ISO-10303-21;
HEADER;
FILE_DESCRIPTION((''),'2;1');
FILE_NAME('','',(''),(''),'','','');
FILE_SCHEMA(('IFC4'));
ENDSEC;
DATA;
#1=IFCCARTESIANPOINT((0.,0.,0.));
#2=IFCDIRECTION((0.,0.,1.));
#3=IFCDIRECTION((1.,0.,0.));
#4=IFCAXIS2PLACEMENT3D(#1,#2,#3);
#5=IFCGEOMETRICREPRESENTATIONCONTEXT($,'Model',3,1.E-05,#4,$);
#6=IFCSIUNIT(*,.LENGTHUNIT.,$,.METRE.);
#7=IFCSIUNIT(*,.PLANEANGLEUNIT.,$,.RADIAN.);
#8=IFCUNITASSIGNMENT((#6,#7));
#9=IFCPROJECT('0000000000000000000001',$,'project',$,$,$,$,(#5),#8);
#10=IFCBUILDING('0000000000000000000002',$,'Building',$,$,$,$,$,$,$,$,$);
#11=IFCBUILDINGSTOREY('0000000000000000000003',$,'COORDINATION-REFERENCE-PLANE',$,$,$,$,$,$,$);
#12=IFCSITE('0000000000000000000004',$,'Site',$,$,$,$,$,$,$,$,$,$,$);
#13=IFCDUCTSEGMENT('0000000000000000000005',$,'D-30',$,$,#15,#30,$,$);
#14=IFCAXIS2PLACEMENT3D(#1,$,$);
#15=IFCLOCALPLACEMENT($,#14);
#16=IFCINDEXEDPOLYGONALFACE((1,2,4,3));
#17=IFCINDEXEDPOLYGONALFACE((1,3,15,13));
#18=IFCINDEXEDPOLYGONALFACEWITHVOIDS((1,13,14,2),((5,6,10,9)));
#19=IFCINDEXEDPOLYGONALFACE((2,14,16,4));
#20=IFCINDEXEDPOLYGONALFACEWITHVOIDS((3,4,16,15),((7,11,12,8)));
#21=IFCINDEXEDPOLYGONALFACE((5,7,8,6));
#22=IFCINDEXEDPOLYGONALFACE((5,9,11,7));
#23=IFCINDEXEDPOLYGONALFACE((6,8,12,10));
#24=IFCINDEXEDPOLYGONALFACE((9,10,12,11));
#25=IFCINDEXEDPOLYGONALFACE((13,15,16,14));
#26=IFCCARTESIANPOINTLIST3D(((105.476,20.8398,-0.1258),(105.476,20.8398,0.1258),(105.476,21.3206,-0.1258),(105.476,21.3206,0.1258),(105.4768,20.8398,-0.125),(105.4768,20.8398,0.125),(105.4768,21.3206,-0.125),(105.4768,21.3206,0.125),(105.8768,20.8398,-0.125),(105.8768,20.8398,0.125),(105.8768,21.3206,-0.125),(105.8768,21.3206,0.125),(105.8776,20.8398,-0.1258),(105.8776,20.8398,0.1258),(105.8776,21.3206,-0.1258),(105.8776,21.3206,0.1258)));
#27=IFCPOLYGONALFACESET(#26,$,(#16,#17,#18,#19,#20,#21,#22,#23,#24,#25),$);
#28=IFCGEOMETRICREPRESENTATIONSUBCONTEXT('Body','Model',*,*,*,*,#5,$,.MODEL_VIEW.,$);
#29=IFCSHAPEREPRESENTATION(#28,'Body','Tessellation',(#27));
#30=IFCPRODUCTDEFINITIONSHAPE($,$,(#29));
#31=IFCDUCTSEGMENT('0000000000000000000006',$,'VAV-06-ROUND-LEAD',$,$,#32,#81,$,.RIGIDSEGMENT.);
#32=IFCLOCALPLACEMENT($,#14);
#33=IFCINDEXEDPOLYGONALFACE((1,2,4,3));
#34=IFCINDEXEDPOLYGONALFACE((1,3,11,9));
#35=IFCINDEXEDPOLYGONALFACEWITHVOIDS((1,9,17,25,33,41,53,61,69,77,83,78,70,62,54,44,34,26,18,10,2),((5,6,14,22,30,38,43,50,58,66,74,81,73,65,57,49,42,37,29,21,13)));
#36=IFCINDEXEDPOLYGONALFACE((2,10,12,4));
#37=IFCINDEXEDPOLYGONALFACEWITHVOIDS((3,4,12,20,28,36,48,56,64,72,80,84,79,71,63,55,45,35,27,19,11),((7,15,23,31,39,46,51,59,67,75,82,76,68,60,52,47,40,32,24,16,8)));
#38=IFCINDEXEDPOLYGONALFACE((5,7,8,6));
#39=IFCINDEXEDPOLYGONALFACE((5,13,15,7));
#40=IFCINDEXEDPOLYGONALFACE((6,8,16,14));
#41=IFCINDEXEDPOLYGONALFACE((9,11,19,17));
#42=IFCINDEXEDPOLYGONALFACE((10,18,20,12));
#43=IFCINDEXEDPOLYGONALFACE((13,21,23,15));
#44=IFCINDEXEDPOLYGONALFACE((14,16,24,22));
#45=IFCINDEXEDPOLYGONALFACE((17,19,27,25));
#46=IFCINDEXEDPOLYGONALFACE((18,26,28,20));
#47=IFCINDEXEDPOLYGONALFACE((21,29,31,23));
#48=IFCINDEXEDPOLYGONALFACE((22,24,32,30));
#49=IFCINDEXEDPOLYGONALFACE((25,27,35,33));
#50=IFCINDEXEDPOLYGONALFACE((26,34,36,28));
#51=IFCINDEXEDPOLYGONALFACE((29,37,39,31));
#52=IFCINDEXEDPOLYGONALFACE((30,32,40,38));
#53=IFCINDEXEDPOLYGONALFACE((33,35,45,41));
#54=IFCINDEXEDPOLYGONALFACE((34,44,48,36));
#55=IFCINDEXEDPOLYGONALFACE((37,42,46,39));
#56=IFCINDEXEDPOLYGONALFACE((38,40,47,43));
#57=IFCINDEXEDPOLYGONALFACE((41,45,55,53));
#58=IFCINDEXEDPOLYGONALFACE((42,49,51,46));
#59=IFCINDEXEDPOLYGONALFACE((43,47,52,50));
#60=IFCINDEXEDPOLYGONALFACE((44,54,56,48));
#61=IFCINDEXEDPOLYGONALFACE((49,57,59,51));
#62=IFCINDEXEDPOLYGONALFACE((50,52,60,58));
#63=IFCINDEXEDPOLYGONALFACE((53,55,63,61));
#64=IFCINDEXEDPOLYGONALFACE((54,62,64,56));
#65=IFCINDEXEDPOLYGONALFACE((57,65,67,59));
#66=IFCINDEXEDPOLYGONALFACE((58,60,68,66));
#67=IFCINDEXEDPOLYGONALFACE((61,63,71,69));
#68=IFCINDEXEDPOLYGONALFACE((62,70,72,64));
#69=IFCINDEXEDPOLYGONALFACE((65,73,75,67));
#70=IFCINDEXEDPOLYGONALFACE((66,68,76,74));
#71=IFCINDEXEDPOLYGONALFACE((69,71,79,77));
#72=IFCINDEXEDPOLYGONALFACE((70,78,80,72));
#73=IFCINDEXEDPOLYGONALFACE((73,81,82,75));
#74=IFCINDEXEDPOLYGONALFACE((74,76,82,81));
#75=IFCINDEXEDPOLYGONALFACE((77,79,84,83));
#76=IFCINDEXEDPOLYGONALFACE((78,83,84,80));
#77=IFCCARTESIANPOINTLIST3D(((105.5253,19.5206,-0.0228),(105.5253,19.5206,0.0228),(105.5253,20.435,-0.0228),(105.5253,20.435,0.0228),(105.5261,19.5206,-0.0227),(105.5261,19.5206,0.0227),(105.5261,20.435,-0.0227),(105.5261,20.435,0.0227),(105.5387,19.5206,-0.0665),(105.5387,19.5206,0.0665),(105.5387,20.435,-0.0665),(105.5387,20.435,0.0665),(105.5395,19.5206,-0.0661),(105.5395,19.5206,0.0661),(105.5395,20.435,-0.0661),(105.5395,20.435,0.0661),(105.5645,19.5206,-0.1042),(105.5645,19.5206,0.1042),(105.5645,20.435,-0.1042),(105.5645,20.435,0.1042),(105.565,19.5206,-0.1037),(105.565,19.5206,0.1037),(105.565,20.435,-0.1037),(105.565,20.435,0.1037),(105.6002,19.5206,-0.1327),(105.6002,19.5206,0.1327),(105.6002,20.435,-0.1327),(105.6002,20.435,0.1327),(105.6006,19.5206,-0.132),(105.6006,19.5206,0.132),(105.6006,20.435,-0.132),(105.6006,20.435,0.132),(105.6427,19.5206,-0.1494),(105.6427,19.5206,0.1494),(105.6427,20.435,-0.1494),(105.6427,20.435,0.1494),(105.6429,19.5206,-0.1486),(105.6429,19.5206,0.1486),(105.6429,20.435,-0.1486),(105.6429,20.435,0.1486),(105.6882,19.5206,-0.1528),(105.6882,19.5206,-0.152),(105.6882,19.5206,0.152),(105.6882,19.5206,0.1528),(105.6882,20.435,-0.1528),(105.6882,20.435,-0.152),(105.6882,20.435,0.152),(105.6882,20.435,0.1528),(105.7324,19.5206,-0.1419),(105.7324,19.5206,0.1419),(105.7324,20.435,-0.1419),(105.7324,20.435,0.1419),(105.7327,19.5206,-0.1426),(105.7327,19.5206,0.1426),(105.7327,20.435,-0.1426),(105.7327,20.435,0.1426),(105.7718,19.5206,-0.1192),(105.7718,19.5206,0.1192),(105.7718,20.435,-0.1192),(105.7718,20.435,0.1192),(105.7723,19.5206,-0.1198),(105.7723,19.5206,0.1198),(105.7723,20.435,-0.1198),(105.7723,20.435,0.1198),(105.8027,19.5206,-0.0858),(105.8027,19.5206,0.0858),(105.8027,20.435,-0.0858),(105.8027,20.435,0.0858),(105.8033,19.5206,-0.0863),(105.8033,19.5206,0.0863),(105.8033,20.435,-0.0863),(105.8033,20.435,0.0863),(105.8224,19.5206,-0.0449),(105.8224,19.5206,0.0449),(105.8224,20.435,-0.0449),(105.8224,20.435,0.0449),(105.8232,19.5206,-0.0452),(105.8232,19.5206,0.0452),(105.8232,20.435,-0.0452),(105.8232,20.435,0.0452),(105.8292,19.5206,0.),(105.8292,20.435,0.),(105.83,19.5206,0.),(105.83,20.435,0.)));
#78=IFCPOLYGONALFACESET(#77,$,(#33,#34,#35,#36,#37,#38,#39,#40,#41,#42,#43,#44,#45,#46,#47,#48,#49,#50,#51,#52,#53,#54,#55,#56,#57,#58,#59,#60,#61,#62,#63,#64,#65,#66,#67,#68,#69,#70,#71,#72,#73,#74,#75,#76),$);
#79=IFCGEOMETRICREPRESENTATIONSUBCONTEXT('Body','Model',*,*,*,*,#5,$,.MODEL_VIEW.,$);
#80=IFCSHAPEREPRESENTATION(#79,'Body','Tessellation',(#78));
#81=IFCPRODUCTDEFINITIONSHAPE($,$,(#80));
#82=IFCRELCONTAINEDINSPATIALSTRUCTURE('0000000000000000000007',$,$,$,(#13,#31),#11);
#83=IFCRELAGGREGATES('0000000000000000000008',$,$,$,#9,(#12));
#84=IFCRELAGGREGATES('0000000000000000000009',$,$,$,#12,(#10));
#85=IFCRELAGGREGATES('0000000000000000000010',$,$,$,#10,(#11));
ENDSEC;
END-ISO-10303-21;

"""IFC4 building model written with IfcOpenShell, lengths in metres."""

from ifc_helpers import new_model, si_unit, frame, origin, origin_with_axes, place, context, subcontext, project, spatial, hollow_rectangle, hollow_circle, extrude, element, save


model = new_model("IFC4")

# Units and contexts
model_context = context("Model", 3, precision=1e-05, world=origin_with_axes())
body_context_1 = subcontext(model_context, "Body", "Model", "MODEL_VIEW")
body_context_2 = subcontext(model_context, "Body", "Model", "MODEL_VIEW")
ifc_project = project(units=[si_unit("LENGTHUNIT", "METRE"), si_unit("PLANEANGLEUNIT", "RADIAN")], contexts=[model_context])

# Site, building, storey
site = spatial("IfcSite", under=ifc_project, Name="Site")
building = spatial("IfcBuilding", under=site, Name="Building")
storey = spatial("IfcBuildingStorey", under=building, Name="COORDINATION-REFERENCE-PLANE")

# Duct segment
duct_segment_1_placement = place(None, frame((105.6768, 20.8398, 0.0), z_axis=(0.0, 1.0, 0.0), x_axis=(1.0, 0.0, 0.0)))
element("IfcDuctSegment", 1, at=duct_segment_1_placement, inside=storey, Name="D-30", context=body_context_1, shape_type="SweptSolid", body=[
    extrude(hollow_rectangle(XDim=0.4016, YDim=0.2516, WallThickness=0.0008), origin(), (0.0, 0.0, 1.0), 0.4808),
])

# Duct segment
duct_segment_2_placement = place(None, frame((105.6768, 20.435, 0.0), z_axis=(0.0, -1.0, 0.0), x_axis=(1.0, 0.0, 0.0)))
element("IfcDuctSegment", 2, at=duct_segment_2_placement, inside=storey, Name="VAV-06-ROUND-LEAD", PredefinedType="RIGIDSEGMENT", context=body_context_2, shape_type="SweptSolid", body=[
    extrude(hollow_circle(Radius=0.1532, WallThickness=0.0008), origin(), (0.0, 0.0, 1.0), 0.9144),
])

save(model, "model.ifc")
